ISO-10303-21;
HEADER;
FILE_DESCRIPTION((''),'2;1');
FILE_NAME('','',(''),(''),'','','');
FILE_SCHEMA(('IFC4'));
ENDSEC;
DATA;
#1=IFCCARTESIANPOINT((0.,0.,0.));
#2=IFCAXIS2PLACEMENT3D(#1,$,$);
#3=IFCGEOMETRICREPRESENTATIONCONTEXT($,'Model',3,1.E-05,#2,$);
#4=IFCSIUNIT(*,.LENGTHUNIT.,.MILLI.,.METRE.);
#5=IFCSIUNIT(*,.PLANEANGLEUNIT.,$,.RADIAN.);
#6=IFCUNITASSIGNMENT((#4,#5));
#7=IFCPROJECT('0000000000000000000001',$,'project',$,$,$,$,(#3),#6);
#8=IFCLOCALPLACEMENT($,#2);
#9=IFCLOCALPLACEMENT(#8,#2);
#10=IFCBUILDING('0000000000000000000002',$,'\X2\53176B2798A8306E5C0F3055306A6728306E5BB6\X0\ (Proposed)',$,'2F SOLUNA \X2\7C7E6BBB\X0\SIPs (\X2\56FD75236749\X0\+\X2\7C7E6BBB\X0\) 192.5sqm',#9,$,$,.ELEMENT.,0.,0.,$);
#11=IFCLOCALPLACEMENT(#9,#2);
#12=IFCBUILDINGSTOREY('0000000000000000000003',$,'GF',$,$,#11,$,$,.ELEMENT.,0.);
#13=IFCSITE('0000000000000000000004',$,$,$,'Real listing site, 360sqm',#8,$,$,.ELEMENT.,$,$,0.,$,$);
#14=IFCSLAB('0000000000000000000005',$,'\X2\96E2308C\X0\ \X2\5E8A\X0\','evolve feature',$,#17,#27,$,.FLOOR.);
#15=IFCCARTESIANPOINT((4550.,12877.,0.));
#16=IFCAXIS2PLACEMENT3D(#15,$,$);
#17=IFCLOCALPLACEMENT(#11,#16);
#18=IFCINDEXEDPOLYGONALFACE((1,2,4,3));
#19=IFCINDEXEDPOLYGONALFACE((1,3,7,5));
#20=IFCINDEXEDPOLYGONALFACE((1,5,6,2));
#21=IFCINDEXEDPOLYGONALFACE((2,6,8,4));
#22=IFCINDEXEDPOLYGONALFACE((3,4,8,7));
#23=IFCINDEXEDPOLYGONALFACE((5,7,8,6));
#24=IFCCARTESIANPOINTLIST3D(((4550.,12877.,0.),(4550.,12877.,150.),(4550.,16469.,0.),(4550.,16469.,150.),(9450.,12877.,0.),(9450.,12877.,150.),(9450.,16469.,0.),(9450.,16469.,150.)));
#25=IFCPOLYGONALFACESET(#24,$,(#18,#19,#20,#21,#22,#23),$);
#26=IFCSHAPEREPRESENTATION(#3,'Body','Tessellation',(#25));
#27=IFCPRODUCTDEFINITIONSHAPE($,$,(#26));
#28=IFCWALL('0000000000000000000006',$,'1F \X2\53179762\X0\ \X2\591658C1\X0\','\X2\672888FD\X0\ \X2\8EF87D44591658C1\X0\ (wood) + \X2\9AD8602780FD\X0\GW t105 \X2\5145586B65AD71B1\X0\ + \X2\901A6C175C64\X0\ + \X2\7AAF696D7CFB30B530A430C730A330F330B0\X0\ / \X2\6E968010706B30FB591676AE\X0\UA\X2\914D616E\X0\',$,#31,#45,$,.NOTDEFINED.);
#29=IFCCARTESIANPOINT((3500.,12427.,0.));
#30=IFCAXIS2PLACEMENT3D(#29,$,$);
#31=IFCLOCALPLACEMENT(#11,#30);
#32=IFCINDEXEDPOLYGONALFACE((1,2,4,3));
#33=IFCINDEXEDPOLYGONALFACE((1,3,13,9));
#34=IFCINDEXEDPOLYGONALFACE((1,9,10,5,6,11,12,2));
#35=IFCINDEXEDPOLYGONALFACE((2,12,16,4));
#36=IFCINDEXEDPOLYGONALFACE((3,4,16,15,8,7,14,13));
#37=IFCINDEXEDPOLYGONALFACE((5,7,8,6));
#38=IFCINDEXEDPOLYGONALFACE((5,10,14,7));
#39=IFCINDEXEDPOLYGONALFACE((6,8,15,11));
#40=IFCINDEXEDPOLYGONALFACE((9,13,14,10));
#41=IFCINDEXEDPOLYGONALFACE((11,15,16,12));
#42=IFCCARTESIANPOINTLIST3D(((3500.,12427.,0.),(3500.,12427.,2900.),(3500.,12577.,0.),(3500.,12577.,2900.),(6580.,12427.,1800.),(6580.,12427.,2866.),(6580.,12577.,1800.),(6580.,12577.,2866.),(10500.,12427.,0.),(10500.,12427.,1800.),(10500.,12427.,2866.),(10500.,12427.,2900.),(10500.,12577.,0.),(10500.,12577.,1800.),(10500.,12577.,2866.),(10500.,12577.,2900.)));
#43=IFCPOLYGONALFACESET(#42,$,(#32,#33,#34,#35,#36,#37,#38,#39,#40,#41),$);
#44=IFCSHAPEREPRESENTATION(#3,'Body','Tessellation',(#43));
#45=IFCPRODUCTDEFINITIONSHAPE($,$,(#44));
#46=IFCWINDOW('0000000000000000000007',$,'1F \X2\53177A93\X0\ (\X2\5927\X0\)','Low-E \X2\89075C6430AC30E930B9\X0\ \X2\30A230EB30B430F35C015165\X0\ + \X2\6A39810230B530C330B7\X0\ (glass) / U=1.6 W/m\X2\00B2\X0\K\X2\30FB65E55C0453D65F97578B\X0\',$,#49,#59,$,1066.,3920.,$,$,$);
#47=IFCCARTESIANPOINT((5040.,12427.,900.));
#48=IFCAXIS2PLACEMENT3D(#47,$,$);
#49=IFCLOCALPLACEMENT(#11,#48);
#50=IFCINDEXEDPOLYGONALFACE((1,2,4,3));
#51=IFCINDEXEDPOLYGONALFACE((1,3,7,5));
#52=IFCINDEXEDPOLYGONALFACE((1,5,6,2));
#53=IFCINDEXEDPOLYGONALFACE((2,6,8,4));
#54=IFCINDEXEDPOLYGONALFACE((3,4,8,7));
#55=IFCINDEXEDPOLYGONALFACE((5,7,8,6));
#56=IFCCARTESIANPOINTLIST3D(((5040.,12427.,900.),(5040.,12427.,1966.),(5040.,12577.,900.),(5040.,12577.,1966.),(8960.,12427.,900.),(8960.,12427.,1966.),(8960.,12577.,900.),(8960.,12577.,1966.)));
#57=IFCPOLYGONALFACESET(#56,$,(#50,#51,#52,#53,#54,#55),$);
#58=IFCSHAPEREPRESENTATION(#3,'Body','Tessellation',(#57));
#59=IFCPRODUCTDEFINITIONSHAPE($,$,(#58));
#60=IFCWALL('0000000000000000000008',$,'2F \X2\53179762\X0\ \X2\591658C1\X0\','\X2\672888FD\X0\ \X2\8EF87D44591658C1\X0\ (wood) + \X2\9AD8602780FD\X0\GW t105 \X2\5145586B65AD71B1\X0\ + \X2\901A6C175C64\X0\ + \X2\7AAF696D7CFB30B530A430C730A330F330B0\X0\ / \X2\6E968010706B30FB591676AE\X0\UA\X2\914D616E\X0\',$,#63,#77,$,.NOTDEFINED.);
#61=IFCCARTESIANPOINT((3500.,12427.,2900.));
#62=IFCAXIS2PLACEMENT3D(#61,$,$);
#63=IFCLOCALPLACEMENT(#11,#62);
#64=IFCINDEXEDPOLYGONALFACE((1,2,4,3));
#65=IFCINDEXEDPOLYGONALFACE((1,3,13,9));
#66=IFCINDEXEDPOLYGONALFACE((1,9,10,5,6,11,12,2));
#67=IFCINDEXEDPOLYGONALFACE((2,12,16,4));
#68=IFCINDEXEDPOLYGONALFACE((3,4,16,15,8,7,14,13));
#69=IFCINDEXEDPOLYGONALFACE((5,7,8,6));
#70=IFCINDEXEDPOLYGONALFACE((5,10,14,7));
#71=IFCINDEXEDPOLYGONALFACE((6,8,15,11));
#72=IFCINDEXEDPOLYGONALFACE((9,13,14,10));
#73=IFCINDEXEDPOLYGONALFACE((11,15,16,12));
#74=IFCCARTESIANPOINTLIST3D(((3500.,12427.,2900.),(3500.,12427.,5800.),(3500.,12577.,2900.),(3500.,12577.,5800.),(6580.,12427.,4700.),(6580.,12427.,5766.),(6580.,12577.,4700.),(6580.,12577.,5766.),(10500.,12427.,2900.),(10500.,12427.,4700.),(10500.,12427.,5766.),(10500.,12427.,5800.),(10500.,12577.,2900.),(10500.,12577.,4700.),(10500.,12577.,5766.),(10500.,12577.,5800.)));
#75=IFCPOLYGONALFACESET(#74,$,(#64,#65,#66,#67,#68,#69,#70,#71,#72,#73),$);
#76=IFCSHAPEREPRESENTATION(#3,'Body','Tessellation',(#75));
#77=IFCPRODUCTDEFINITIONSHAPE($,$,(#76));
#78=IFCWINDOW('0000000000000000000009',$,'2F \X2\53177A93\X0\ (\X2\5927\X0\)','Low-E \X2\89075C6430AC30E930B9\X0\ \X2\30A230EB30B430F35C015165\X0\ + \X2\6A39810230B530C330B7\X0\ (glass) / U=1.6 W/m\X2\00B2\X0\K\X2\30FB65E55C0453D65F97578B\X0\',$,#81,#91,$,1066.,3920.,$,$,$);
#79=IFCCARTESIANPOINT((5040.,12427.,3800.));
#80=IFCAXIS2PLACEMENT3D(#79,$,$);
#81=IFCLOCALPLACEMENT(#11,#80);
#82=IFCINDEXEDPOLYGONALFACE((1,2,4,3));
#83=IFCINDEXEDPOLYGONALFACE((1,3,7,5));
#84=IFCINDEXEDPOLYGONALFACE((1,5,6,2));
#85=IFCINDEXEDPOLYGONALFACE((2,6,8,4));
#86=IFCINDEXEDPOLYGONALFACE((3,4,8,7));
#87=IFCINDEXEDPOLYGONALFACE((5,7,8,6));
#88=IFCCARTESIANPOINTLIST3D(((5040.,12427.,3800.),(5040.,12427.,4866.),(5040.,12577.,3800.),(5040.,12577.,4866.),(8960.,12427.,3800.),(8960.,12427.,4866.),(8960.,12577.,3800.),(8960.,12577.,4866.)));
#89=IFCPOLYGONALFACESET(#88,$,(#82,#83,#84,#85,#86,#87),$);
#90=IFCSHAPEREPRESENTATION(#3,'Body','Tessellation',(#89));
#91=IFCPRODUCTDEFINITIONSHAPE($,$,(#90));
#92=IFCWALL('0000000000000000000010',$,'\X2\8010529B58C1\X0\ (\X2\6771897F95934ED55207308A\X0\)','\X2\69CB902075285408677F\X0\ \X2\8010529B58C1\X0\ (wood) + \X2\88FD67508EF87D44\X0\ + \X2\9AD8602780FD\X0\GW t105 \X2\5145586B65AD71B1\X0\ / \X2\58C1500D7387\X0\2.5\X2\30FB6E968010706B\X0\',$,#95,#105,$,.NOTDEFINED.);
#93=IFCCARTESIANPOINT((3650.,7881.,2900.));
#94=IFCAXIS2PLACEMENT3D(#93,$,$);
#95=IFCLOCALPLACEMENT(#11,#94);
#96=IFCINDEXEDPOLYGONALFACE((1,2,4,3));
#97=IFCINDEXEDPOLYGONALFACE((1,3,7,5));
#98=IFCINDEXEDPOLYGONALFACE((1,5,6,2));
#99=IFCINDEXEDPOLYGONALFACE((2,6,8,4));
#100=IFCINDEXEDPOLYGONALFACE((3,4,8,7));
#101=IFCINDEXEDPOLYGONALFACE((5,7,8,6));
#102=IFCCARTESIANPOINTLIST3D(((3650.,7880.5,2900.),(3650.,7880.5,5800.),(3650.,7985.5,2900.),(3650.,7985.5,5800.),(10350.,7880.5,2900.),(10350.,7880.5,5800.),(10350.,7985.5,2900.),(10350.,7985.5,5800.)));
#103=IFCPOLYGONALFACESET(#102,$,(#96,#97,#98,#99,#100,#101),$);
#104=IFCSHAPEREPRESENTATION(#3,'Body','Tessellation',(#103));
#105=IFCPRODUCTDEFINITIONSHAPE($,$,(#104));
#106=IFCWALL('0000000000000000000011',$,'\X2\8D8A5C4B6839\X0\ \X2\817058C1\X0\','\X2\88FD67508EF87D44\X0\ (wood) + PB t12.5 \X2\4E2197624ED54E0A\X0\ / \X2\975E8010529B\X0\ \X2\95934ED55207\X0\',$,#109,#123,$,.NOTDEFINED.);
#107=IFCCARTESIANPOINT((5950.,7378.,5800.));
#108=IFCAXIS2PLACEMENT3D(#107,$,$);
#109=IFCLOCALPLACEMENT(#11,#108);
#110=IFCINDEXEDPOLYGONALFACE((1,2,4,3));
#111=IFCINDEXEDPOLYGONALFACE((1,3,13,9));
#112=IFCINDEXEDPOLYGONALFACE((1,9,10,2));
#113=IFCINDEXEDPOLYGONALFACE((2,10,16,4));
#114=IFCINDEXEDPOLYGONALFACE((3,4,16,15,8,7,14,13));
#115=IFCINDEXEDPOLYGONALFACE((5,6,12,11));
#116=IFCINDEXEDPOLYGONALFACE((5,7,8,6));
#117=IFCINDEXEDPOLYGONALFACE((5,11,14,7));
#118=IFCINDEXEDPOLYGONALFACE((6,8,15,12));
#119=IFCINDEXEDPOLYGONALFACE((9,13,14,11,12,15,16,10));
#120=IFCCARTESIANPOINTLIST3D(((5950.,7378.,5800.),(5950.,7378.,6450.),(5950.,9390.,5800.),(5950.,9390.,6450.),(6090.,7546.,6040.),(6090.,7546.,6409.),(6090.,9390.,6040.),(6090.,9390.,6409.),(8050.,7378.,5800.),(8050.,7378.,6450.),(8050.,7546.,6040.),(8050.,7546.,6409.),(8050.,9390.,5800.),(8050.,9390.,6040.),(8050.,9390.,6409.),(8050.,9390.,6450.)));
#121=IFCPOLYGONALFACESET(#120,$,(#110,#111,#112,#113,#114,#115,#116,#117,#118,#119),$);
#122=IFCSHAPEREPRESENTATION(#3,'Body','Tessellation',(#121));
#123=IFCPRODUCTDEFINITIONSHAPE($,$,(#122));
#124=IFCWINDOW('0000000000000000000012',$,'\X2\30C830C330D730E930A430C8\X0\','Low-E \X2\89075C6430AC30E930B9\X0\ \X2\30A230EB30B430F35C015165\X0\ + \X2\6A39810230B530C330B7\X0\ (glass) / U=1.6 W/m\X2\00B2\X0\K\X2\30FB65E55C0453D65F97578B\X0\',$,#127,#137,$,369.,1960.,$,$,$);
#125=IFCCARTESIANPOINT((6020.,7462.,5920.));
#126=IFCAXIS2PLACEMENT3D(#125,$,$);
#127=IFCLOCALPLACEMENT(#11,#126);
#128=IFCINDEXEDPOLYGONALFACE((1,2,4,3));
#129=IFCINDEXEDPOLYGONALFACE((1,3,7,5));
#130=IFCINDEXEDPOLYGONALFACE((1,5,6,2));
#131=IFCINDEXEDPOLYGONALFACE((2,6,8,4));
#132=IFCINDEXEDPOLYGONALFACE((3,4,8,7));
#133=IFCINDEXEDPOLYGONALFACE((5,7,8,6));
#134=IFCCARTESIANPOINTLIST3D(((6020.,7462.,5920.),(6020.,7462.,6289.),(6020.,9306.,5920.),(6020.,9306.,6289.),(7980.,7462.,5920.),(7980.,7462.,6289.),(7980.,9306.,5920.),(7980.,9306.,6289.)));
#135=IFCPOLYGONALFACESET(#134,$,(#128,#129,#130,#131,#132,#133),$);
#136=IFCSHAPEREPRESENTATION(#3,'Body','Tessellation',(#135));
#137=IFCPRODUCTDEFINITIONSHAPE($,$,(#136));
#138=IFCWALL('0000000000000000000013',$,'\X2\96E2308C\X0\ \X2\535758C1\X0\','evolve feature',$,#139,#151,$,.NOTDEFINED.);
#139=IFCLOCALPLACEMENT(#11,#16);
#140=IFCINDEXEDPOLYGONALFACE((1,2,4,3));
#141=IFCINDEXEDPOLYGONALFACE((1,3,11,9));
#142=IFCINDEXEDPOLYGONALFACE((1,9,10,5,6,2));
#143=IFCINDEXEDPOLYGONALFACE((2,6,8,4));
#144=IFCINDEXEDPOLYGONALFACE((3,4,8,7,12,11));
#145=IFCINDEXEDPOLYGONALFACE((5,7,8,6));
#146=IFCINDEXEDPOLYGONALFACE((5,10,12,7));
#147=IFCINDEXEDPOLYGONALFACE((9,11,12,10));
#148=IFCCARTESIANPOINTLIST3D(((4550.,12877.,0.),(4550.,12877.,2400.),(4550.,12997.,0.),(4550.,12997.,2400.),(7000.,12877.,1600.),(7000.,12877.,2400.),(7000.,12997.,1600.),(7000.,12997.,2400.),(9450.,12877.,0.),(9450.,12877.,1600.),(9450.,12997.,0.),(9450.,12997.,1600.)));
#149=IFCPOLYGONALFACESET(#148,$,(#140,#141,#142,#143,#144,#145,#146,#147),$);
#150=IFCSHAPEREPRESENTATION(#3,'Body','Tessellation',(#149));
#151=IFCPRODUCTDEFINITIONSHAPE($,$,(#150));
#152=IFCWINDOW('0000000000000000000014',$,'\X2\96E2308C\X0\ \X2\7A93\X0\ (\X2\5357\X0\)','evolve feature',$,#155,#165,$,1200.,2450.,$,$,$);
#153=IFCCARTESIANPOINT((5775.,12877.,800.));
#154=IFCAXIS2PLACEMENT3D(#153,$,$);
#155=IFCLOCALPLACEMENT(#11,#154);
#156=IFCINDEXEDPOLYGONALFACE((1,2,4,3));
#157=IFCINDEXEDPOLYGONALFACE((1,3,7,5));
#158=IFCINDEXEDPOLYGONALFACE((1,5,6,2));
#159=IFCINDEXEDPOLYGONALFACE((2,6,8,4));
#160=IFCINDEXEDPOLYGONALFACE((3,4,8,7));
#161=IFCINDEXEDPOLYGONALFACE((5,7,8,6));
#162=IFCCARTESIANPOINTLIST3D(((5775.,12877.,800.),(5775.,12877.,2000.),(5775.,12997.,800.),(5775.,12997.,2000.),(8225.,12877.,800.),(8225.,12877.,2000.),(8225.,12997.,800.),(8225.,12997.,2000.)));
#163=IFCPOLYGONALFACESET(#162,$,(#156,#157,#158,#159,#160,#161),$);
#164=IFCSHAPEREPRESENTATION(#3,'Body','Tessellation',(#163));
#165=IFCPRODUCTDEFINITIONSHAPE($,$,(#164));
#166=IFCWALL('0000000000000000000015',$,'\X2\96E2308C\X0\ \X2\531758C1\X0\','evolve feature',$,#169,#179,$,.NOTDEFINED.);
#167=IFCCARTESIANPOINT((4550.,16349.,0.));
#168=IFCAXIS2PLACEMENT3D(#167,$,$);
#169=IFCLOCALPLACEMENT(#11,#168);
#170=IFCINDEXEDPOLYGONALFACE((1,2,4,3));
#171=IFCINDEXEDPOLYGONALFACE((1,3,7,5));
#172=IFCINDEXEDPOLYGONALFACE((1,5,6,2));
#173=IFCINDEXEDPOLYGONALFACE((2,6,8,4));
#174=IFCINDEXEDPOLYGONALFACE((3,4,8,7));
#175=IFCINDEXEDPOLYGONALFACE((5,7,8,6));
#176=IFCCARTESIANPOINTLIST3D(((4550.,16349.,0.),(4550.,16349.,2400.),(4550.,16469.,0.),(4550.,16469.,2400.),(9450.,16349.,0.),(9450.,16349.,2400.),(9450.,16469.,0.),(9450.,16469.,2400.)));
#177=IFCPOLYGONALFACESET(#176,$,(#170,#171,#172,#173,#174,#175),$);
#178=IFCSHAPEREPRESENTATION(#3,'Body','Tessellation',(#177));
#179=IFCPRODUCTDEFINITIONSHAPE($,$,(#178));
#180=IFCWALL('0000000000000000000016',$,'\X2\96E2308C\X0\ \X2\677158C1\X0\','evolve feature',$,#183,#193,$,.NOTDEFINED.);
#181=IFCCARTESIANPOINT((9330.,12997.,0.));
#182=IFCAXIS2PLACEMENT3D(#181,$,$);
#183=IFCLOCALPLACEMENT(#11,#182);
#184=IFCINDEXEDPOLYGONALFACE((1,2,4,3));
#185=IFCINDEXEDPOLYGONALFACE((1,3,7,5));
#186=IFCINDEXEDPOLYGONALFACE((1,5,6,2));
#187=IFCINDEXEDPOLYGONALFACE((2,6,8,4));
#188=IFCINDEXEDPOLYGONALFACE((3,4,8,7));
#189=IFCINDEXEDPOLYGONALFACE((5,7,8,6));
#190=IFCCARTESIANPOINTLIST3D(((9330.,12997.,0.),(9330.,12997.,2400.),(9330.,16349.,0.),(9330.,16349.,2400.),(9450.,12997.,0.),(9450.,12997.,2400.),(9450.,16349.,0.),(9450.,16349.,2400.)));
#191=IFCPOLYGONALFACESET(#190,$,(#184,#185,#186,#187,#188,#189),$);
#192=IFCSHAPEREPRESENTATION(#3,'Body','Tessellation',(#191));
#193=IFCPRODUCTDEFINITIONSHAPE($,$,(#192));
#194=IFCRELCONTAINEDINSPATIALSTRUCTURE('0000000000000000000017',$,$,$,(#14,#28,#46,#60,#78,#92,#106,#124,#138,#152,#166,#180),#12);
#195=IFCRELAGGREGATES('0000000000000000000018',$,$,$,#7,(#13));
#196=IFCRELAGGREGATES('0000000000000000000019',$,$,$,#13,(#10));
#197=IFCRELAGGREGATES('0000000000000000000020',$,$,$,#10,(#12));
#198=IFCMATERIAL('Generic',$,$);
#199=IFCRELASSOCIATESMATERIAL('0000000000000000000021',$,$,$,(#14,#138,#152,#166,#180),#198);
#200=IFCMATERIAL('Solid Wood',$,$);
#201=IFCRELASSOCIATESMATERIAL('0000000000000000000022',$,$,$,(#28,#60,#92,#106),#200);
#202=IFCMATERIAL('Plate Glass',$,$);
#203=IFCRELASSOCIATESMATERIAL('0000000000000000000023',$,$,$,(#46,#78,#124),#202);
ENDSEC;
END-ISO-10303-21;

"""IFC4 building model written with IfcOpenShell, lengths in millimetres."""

from ifc_helpers import new_model, si_unit, frame, frame_2d, origin, place, context, project, spatial, rectangle, extrude, material, element, fill, save


model = new_model("IFC4")

# Units and contexts
model_context = context("Model", 3, precision=1e-05, world=origin())
ifc_project = project(units=[si_unit("LENGTHUNIT", "METRE", prefix="MILLI"), si_unit("PLANEANGLEUNIT", "RADIAN")], contexts=[model_context])

# Site, building, storey
site_placement = place(None, origin())
site = spatial("IfcSite", under=ifc_project, at=site_placement, ObjectType="Real listing site, 360sqm", CompositionType="ELEMENT", RefElevation=0.0)
building_placement = place(site_placement, origin())
building = spatial("IfcBuilding", under=site, at=building_placement, Name="北欧風の小さな木の家 (Proposed)", ObjectType="2F SOLUNA 籾殻SIPs (国産杉+籾殻) 192.5sqm", CompositionType="ELEMENT", ElevationOfRefHeight=0.0, ElevationOfTerrain=0.0)
storey_placement = place(building_placement, origin())
storey = spatial("IfcBuildingStorey", under=building, at=storey_placement, Name="GF", CompositionType="ELEMENT", Elevation=0.0)

# Slab
ifc_material_1 = material(Name="Generic")
slab_placement = place(storey_placement, frame((4550.0, 12877.0, 0.0)))
element("IfcSlab", 1, at=slab_placement, inside=storey, material=ifc_material_1, Name="離れ 床", Description="evolve feature", PredefinedType="FLOOR", context=model_context, shape_type="SweptSolid", body=[
    extrude(rectangle(XDim=4900.0, YDim=3592.0, at=frame_2d((2450.0, 1796.0))), frame((4550.0, 12877.0, 0.0)), (0.0, 0.0, 1.0), 150.0),
])

# Wall, opening, window
ifc_material_2 = material(Name="Solid Wood")
wall_1_placement = place(storey_placement, frame((3500.0, 12427.0, 0.0)))
wall_1 = element("IfcWall", 2, at=wall_1_placement, inside=storey, material=ifc_material_2, Name="1F 北面 外壁", Description="木製 軸組外壁 (wood) + 高性能GW t105 充填断熱 + 通気層 + 窯業系サイディング / 準耐火・外皮UA配慮", PredefinedType="NOTDEFINED", context=model_context, shape_type="SweptSolid", body=[
    extrude(rectangle(XDim=7000.0, YDim=150.0, at=frame_2d((3500.0, 75.0))), frame((3500.0, 12427.0, 0.0)), (0.0, 0.0, 1.0), 2900.0),
])
opening_1_placement = place(storey_placement, frame((5040.0, 12427.0, 900.0)))
opening_1 = element("IfcOpeningElement", 3, at=opening_1_placement, cuts=wall_1, PredefinedType="NOTDEFINED", context=model_context, shape_type="SweptSolid", body=[
    extrude(rectangle(XDim=3920.0, YDim=150.0, at=frame_2d((1960.0, 75.0))), frame((5040.0, 12427.0, 900.0)), (0.0, 0.0, 1.0), 1066.0),
])
ifc_material_3 = material(Name="Plate Glass")
window_1_placement = place(storey_placement, frame((5040.0, 12427.0, 900.0)))
window_1 = element("IfcWindow", 4, at=window_1_placement, inside=storey, material=ifc_material_3, Name="1F 北窓 (大)", Description="Low-E 複層ガラス アルゴン封入 + 樹脂サッシ (glass) / U=1.6 W/m²K・日射取得型", OverallHeight=1066.0, OverallWidth=3920.0, context=model_context, shape_type="SweptSolid", body=[
    extrude(rectangle(XDim=3920.0, YDim=150.0, at=frame_2d((1960.0, 75.0))), frame((5040.0, 12427.0, 900.0)), (0.0, 0.0, 1.0), 1066.0),
])
fill(opening_1, window_1)

# Wall, opening, window
wall_2_placement = place(storey_placement, frame((3500.0, 12427.0, 2900.0)))
wall_2 = element("IfcWall", 5, at=wall_2_placement, inside=storey, material=ifc_material_2, Name="2F 北面 外壁", Description="木製 軸組外壁 (wood) + 高性能GW t105 充填断熱 + 通気層 + 窯業系サイディング / 準耐火・外皮UA配慮", PredefinedType="NOTDEFINED", context=model_context, shape_type="SweptSolid", body=[
    extrude(rectangle(XDim=7000.0, YDim=150.0, at=frame_2d((3500.0, 75.0))), frame((3500.0, 12427.0, 2900.0)), (0.0, 0.0, 1.0), 2900.0),
])
opening_2_placement = place(storey_placement, frame((5040.0, 12427.0, 3800.0)))
opening_2 = element("IfcOpeningElement", 6, at=opening_2_placement, cuts=wall_2, PredefinedType="NOTDEFINED", context=model_context, shape_type="SweptSolid", body=[
    extrude(rectangle(XDim=3920.0, YDim=150.0, at=frame_2d((1960.0, 75.0))), frame((5040.0, 12427.0, 3800.0)), (0.0, 0.0, 1.0), 1066.0),
])
window_2_placement = place(storey_placement, frame((5040.0, 12427.0, 3800.0)))
window_2 = element("IfcWindow", 7, at=window_2_placement, inside=storey, material=ifc_material_3, Name="2F 北窓 (大)", Description="Low-E 複層ガラス アルゴン封入 + 樹脂サッシ (glass) / U=1.6 W/m²K・日射取得型", OverallHeight=1066.0, OverallWidth=3920.0, context=model_context, shape_type="SweptSolid", body=[
    extrude(rectangle(XDim=3920.0, YDim=150.0, at=frame_2d((1960.0, 75.0))), frame((5040.0, 12427.0, 3800.0)), (0.0, 0.0, 1.0), 1066.0),
])
fill(opening_2, window_2)

# Wall
wall_3_placement = place(storey_placement, frame((3650.0, 7881.0, 2900.0)))
element("IfcWall", 8, at=wall_3_placement, inside=storey, material=ifc_material_2, Name="耐力壁 (東西間仕切り)", Description="構造用合板 耐力壁 (wood) + 製材軸組 + 高性能GW t105 充填断熱 / 壁倍率2.5・準耐火", PredefinedType="NOTDEFINED", context=model_context, shape_type="SweptSolid", body=[
    extrude(rectangle(XDim=6700.0, YDim=105.0, at=frame_2d((3350.0, 52.0))), frame((3650.0, 7881.0, 2900.0)), (0.0, 0.0, 1.0), 2900.0),
])

# Walls, openings, windows
wall_4_placement = place(storey_placement, frame((5950.0, 7378.0, 5800.0)))
wall_4 = element("IfcWall", 9, at=wall_4_placement, inside=storey, material=ifc_material_2, Name="越屋根 腰壁", Description="製材軸組 (wood) + PB t12.5 両面仕上 / 非耐力 間仕切", PredefinedType="NOTDEFINED", context=model_context, shape_type="SweptSolid", body=[
    extrude(rectangle(XDim=2100.0, YDim=2012.0, at=frame_2d((1050.0, 1006.0))), frame((5950.0, 7378.0, 5800.0)), (0.0, 0.0, 1.0), 650.0),
])
opening_3_placement = place(storey_placement, frame((6020.0, 7462.0, 5920.0)))
opening_3 = element("IfcOpeningElement", 10, at=opening_3_placement, cuts=wall_4, PredefinedType="NOTDEFINED", context=model_context, shape_type="SweptSolid", body=[
    extrude(rectangle(XDim=1960.0, YDim=1844.0, at=frame_2d((980.0, 922.0))), frame((6020.0, 7462.0, 5920.0)), (0.0, 0.0, 1.0), 369.0),
])
window_3_placement = place(storey_placement, frame((6020.0, 7462.0, 5920.0)))
window_3 = element("IfcWindow", 11, at=window_3_placement, inside=storey, material=ifc_material_3, Name="トップライト", Description="Low-E 複層ガラス アルゴン封入 + 樹脂サッシ (glass) / U=1.6 W/m²K・日射取得型", OverallHeight=369.0, OverallWidth=1960.0, context=model_context, shape_type="SweptSolid", body=[
    extrude(rectangle(XDim=1960.0, YDim=1844.0, at=frame_2d((980.0, 922.0))), frame((6020.0, 7462.0, 5920.0)), (0.0, 0.0, 1.0), 369.0),
])
fill(opening_3, window_3)
wall_5_placement = place(storey_placement, frame((4550.0, 12877.0, 0.0)))
wall_5 = element("IfcWall", 12, at=wall_5_placement, inside=storey, material=ifc_material_1, Name="離れ 南壁", Description="evolve feature", PredefinedType="NOTDEFINED", context=model_context, shape_type="SweptSolid", body=[
    extrude(rectangle(XDim=4900.0, YDim=120.0, at=frame_2d((2450.0, 60.0))), frame((4550.0, 12877.0, 0.0)), (0.0, 0.0, 1.0), 2400.0),
])
opening_4_placement = place(storey_placement, frame((5775.0, 12877.0, 800.0)))
opening_4 = element("IfcOpeningElement", 13, at=opening_4_placement, cuts=wall_5, PredefinedType="NOTDEFINED", context=model_context, shape_type="SweptSolid", body=[
    extrude(rectangle(XDim=2450.0, YDim=120.0, at=frame_2d((1225.0, 60.0))), frame((5775.0, 12877.0, 800.0)), (0.0, 0.0, 1.0), 1200.0),
])
window_4_placement = place(storey_placement, frame((5775.0, 12877.0, 800.0)))
window_4 = element("IfcWindow", 14, at=window_4_placement, inside=storey, material=ifc_material_1, Name="離れ 窓 (南)", Description="evolve feature", OverallHeight=1200.0, OverallWidth=2450.0, context=model_context, shape_type="SweptSolid", body=[
    extrude(rectangle(XDim=2450.0, YDim=120.0, at=frame_2d((1225.0, 60.0))), frame((5775.0, 12877.0, 800.0)), (0.0, 0.0, 1.0), 1200.0),
])
fill(opening_4, window_4)

# Walls
wall_6_placement = place(storey_placement, frame((4550.0, 16349.0, 0.0)))
element("IfcWall", 15, at=wall_6_placement, inside=storey, material=ifc_material_1, Name="離れ 北壁", Description="evolve feature", PredefinedType="NOTDEFINED", context=model_context, shape_type="SweptSolid", body=[
    extrude(rectangle(XDim=4900.0, YDim=120.0, at=frame_2d((2450.0, 60.0))), frame((4550.0, 16349.0, 0.0)), (0.0, 0.0, 1.0), 2400.0),
])
wall_7_placement = place(storey_placement, frame((9330.0, 12997.0, 0.0)))
element("IfcWall", 16, at=wall_7_placement, inside=storey, material=ifc_material_1, Name="離れ 東壁", Description="evolve feature", PredefinedType="NOTDEFINED", context=model_context, shape_type="SweptSolid", body=[
    extrude(rectangle(XDim=120.0, YDim=3352.0, at=frame_2d((60.0, 1676.0))), frame((9330.0, 12997.0, 0.0)), (0.0, 0.0, 1.0), 2400.0),
])

save(model, "model.ifc")
